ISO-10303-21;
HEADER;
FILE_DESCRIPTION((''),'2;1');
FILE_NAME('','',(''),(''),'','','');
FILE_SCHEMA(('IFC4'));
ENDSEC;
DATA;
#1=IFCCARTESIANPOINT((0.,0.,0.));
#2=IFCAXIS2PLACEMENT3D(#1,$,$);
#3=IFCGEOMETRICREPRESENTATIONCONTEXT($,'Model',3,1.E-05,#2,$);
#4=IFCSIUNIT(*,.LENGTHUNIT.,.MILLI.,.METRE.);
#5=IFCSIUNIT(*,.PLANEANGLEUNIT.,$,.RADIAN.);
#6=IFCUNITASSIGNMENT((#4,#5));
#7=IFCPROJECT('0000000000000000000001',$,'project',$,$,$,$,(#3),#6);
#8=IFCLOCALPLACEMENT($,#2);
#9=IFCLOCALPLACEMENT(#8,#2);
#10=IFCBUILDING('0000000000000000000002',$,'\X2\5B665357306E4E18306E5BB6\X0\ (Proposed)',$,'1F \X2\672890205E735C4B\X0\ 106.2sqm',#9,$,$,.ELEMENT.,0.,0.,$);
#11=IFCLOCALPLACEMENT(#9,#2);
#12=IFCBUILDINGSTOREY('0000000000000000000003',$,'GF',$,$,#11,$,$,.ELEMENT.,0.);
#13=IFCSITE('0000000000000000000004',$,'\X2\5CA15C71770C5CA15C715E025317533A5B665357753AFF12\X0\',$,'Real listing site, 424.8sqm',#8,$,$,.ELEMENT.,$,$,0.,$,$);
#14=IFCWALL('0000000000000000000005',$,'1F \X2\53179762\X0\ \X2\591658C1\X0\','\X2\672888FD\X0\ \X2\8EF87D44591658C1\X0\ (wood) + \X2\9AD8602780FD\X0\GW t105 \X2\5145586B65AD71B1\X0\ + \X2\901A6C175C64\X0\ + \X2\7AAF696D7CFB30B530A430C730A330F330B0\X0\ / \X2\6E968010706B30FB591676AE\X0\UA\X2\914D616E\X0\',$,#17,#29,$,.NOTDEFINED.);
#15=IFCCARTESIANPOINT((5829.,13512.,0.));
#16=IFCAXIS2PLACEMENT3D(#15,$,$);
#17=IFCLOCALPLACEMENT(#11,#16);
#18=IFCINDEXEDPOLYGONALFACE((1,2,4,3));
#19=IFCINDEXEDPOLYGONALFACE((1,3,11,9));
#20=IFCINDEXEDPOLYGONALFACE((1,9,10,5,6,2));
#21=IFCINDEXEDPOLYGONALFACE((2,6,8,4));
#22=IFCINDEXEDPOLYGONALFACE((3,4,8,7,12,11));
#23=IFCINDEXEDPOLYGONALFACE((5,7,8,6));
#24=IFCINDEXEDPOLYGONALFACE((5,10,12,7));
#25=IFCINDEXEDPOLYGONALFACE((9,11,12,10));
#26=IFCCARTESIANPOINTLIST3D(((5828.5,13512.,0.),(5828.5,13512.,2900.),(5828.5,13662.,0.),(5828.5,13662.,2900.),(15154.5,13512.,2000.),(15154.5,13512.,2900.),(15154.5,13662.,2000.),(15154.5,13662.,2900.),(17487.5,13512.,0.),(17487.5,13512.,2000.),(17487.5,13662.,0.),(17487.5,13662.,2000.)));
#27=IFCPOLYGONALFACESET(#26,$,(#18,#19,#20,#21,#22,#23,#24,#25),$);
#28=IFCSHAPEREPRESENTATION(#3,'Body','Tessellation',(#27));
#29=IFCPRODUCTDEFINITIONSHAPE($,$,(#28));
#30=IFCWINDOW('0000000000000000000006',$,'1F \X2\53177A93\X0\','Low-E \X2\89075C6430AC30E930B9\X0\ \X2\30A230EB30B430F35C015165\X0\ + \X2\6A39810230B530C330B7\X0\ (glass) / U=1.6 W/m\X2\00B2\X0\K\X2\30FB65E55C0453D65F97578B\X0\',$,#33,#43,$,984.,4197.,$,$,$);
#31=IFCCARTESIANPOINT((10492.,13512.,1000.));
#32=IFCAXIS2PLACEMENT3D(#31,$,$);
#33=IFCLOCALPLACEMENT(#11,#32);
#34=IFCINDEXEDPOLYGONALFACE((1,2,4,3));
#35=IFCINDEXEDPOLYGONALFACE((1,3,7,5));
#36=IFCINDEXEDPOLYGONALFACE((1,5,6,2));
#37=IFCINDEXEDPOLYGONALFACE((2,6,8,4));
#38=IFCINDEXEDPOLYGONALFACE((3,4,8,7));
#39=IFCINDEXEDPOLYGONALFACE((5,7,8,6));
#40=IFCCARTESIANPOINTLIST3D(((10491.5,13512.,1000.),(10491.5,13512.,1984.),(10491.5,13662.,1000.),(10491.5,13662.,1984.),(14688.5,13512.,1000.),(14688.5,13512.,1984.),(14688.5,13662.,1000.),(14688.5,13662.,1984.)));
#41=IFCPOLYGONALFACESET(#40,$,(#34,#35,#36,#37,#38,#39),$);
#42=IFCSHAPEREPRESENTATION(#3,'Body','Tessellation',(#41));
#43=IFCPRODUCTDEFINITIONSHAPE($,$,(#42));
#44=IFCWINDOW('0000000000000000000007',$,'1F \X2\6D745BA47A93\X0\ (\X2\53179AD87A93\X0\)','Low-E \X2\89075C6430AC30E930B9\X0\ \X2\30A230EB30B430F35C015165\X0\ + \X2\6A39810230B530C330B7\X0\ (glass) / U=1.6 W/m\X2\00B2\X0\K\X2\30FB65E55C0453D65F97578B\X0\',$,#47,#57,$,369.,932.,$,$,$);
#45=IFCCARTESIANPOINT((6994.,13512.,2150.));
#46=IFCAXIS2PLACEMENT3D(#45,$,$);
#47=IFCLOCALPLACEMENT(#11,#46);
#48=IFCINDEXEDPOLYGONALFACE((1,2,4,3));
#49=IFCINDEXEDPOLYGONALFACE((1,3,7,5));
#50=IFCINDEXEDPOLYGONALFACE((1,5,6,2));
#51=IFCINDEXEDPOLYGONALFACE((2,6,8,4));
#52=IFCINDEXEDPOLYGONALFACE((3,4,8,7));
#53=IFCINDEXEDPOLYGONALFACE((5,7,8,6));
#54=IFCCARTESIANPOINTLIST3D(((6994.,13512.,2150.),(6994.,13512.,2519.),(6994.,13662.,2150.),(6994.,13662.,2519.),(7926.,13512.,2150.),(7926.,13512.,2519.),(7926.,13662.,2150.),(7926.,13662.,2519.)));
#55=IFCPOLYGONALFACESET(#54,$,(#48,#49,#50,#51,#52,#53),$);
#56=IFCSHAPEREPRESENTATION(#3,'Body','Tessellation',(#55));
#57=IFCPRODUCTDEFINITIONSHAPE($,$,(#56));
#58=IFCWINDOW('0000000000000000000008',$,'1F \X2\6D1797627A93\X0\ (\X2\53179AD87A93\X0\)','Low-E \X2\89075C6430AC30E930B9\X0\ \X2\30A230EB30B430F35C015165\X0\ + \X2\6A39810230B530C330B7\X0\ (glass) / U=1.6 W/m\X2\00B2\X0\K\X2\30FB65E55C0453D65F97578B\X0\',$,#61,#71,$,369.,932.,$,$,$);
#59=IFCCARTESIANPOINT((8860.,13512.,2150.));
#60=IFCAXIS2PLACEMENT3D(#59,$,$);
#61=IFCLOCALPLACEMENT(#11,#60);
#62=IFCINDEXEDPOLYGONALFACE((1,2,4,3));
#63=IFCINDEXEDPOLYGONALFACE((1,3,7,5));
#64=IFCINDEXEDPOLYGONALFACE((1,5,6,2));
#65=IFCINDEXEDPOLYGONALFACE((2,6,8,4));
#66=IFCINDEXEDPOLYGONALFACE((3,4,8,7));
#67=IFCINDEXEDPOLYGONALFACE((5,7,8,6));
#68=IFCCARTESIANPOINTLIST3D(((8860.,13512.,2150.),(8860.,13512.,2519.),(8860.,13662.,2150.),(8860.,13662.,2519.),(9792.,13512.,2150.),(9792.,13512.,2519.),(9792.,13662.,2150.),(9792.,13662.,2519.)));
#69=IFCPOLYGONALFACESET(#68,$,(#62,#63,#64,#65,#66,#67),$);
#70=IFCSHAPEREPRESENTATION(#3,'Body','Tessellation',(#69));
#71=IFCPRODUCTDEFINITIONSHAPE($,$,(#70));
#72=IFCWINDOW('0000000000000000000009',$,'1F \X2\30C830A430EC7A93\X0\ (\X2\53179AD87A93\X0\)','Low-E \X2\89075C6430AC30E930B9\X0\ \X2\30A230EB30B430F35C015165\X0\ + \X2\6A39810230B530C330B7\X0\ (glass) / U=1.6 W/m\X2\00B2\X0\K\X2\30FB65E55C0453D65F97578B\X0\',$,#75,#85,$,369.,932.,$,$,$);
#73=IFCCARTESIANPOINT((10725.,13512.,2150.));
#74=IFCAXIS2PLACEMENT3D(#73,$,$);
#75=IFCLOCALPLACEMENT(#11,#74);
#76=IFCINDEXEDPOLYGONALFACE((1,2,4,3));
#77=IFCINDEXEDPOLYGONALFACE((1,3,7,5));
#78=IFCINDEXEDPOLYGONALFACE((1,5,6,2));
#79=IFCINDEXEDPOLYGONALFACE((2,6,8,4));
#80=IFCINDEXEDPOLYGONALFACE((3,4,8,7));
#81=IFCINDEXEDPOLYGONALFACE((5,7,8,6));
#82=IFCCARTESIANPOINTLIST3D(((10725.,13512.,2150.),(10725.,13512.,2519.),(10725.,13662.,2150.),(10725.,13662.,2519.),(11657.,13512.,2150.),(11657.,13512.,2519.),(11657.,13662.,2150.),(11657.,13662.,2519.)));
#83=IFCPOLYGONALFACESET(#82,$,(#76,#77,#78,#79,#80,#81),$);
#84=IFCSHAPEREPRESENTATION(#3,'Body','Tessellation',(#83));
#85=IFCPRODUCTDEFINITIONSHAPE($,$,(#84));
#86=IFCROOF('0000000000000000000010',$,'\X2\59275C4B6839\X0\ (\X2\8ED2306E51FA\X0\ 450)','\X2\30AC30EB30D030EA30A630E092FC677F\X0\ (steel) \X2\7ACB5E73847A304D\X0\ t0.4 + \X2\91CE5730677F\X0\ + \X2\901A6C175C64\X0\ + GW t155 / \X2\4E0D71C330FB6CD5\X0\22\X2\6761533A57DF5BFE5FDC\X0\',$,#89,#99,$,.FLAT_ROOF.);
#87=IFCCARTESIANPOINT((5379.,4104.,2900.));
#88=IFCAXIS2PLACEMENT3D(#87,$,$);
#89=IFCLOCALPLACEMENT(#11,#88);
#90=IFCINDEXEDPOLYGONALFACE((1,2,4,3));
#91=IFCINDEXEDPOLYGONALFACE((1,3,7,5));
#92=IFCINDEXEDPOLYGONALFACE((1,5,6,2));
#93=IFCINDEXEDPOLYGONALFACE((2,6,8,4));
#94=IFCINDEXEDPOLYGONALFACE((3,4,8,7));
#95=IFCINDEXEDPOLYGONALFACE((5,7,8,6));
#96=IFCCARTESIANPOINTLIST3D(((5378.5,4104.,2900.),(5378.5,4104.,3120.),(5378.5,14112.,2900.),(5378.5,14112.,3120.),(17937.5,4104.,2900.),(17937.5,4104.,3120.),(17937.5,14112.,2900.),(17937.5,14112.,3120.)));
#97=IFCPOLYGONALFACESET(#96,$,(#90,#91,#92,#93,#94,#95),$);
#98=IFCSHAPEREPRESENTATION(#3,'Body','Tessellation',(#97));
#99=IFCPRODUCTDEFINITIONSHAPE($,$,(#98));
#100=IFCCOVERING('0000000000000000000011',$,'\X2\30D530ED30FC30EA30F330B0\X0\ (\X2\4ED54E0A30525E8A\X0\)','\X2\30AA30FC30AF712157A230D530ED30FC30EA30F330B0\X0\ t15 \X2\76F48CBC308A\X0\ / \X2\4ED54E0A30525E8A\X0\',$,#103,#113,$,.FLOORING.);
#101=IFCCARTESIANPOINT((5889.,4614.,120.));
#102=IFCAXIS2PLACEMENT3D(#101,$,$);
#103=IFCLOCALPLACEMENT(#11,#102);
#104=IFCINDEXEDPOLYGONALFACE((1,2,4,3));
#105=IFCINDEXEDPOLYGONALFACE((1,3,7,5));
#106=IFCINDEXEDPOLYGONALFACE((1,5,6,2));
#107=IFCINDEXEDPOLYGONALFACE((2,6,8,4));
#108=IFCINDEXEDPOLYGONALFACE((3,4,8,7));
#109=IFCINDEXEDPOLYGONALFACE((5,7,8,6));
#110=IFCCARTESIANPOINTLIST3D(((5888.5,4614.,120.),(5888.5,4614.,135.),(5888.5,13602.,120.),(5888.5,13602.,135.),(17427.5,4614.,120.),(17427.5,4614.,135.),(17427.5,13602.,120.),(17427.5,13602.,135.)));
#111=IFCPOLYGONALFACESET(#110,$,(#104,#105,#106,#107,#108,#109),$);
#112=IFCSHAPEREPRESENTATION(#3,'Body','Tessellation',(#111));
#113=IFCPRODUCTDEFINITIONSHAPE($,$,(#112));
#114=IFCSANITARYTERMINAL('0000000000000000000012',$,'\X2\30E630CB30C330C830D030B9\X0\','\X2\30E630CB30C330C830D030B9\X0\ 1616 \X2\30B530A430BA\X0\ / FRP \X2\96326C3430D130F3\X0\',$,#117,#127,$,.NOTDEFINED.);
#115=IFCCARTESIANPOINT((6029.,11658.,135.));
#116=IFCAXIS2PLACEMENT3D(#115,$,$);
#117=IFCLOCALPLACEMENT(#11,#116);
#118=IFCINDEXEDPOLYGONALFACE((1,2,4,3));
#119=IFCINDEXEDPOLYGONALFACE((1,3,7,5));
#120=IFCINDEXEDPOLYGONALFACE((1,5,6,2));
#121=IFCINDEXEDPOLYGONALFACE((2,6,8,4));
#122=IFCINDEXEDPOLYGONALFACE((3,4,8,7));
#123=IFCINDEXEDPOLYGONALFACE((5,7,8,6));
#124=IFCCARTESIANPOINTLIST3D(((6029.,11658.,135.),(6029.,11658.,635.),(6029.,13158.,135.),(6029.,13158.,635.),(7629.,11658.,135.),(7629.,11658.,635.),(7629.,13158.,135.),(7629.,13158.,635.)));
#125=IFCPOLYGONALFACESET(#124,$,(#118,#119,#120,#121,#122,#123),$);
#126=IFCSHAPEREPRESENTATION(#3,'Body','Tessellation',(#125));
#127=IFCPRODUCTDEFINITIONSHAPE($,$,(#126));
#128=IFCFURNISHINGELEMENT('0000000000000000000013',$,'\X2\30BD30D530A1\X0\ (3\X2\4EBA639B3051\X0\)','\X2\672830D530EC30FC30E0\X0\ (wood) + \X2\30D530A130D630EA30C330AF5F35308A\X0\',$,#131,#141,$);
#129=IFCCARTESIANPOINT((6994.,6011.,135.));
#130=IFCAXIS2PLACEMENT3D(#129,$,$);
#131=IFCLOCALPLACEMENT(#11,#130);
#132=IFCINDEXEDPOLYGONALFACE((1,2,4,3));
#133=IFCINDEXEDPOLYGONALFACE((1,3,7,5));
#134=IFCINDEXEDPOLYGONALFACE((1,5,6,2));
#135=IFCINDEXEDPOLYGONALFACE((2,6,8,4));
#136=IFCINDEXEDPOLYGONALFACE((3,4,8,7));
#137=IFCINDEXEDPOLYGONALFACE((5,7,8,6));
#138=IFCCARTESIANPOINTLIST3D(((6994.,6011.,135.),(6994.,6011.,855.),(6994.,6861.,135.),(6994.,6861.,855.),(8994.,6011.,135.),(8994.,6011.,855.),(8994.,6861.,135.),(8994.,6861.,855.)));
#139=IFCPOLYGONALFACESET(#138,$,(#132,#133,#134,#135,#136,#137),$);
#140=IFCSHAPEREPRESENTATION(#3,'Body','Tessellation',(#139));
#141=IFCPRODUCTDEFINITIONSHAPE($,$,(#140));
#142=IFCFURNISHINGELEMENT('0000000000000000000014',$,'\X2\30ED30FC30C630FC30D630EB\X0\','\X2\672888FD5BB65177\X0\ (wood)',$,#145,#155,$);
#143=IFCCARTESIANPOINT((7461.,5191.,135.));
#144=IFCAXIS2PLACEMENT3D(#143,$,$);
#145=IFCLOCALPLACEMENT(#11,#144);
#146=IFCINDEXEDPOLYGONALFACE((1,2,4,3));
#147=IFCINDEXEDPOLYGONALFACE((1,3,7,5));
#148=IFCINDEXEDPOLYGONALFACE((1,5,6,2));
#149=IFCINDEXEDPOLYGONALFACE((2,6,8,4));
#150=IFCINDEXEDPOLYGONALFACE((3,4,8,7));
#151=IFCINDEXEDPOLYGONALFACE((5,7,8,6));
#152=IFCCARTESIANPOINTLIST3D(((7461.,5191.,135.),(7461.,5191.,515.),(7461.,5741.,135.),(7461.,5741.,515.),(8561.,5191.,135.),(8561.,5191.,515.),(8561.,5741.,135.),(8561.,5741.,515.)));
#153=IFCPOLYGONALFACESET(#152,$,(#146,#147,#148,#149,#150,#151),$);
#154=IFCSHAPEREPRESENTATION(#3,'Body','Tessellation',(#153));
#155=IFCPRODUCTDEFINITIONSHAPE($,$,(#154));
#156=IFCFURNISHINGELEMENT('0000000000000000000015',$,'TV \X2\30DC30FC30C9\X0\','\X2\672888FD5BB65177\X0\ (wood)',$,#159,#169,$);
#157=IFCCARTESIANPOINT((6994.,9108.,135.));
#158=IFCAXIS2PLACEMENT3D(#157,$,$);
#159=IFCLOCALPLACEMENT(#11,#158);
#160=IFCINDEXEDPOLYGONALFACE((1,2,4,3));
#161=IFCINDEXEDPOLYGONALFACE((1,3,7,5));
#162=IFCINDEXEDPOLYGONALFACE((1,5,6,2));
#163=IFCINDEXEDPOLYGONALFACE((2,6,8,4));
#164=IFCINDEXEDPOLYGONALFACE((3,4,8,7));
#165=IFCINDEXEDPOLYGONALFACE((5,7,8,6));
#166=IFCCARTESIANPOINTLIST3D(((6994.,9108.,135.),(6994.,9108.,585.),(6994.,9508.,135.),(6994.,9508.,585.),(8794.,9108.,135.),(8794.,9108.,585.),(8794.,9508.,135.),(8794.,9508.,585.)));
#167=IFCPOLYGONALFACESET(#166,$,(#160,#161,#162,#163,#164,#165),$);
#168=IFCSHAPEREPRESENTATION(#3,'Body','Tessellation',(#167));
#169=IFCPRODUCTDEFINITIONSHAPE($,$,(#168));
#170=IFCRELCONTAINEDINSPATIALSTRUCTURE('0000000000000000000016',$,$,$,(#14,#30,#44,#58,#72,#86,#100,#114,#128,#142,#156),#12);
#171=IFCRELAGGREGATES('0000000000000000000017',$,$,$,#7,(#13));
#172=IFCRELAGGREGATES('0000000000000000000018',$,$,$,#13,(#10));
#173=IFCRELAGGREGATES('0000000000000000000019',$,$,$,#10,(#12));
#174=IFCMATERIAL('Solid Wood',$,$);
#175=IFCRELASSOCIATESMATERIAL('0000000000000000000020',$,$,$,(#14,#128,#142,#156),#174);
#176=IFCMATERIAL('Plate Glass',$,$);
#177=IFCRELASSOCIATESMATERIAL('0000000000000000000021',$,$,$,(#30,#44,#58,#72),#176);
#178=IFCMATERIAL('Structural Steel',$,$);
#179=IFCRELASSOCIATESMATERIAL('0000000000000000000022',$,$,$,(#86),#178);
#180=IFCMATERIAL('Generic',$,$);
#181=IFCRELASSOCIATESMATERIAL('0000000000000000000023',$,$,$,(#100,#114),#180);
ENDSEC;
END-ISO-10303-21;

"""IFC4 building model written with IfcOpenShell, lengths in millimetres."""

from ifc_helpers import new_model, si_unit, frame, frame_2d, origin, place, context, project, spatial, rectangle, extrude, material, element, fill, save


model = new_model("IFC4")

# Units and contexts
model_context = context("Model", 3, precision=1e-05, world=origin())
ifc_project = project(units=[si_unit("LENGTHUNIT", "METRE", prefix="MILLI"), si_unit("PLANEANGLEUNIT", "RADIAN")], contexts=[model_context])

# Site, building, storey
site_placement = place(None, origin())
site = spatial("IfcSite", under=ifc_project, at=site_placement, Name="岡山県岡山市北区学南町２", ObjectType="Real listing site, 424.8sqm", CompositionType="ELEMENT", RefElevation=0.0)
building_placement = place(site_placement, origin())
building = spatial("IfcBuilding", under=site, at=building_placement, Name="学南の丘の家 (Proposed)", ObjectType="1F 木造平屋 106.2sqm", CompositionType="ELEMENT", ElevationOfRefHeight=0.0, ElevationOfTerrain=0.0)
storey_placement = place(building_placement, origin())
storey = spatial("IfcBuildingStorey", under=building, at=storey_placement, Name="GF", CompositionType="ELEMENT", Elevation=0.0)

# Shared definitions
ifc_material_1 = material(Name="Solid Wood")

# Shared definitions
ifc_material_2 = material(Name="Plate Glass")

# Wall, openings, windows
wall_1_placement = place(storey_placement, frame((5829.0, 13512.0, 0.0)))
wall_1 = element("IfcWall", 1, at=wall_1_placement, inside=storey, material=ifc_material_1, Name="1F 北面 外壁", Description="木製 軸組外壁 (wood) + 高性能GW t105 充填断熱 + 通気層 + 窯業系サイディング / 準耐火・外皮UA配慮", PredefinedType="NOTDEFINED", context=model_context, shape_type="SweptSolid", body=[
    extrude(rectangle(XDim=11659.0, YDim=150.0, at=frame_2d((5829.0, 75.0))), frame((5829.0, 13512.0, 0.0)), (0.0, 0.0, 1.0), 2900.0),
])
opening_1_placement = place(storey_placement, frame((10492.0, 13512.0, 1000.0)))
opening_1 = element("IfcOpeningElement", 2, at=opening_1_placement, cuts=wall_1, PredefinedType="NOTDEFINED", context=model_context, shape_type="SweptSolid", body=[
    extrude(rectangle(XDim=4197.0, YDim=150.0, at=frame_2d((2098.0, 75.0))), frame((10492.0, 13512.0, 1000.0)), (0.0, 0.0, 1.0), 984.0),
])
opening_2_placement = place(storey_placement, frame((6994.0, 13512.0, 2150.0)))
opening_2 = element("IfcOpeningElement", 3, at=opening_2_placement, cuts=wall_1, PredefinedType="NOTDEFINED", context=model_context, shape_type="SweptSolid", body=[
    extrude(rectangle(XDim=932.0, YDim=150.0, at=frame_2d((466.0, 75.0))), frame((6994.0, 13512.0, 2150.0)), (0.0, 0.0, 1.0), 369.0),
])
opening_3_placement = place(storey_placement, frame((8860.0, 13512.0, 2150.0)))
opening_3 = element("IfcOpeningElement", 4, at=opening_3_placement, cuts=wall_1, PredefinedType="NOTDEFINED", context=model_context, shape_type="SweptSolid", body=[
    extrude(rectangle(XDim=932.0, YDim=150.0, at=frame_2d((466.0, 75.0))), frame((8860.0, 13512.0, 2150.0)), (0.0, 0.0, 1.0), 369.0),
])
opening_4_placement = place(storey_placement, frame((10725.0, 13512.0, 2150.0)))
opening_4 = element("IfcOpeningElement", 5, at=opening_4_placement, cuts=wall_1, PredefinedType="NOTDEFINED", context=model_context, shape_type="SweptSolid", body=[
    extrude(rectangle(XDim=932.0, YDim=150.0, at=frame_2d((466.0, 75.0))), frame((10725.0, 13512.0, 2150.0)), (0.0, 0.0, 1.0), 369.0),
])
window_1_placement = place(storey_placement, frame((10492.0, 13512.0, 1000.0)))
window_1 = element("IfcWindow", 6, at=window_1_placement, inside=storey, material=ifc_material_2, Name="1F 北窓", Description="Low-E 複層ガラス アルゴン封入 + 樹脂サッシ (glass) / U=1.6 W/m²K・日射取得型", OverallHeight=984.0, OverallWidth=4197.0, context=model_context, shape_type="SweptSolid", body=[
    extrude(rectangle(XDim=4197.0, YDim=150.0, at=frame_2d((2098.0, 75.0))), frame((10492.0, 13512.0, 1000.0)), (0.0, 0.0, 1.0), 984.0),
])
fill(opening_1, window_1)
window_2_placement = place(storey_placement, frame((6994.0, 13512.0, 2150.0)))
window_2 = element("IfcWindow", 7, at=window_2_placement, inside=storey, material=ifc_material_2, Name="1F 浴室窓 (北高窓)", Description="Low-E 複層ガラス アルゴン封入 + 樹脂サッシ (glass) / U=1.6 W/m²K・日射取得型", OverallHeight=369.0, OverallWidth=932.0, context=model_context, shape_type="SweptSolid", body=[
    extrude(rectangle(XDim=932.0, YDim=150.0, at=frame_2d((466.0, 75.0))), frame((6994.0, 13512.0, 2150.0)), (0.0, 0.0, 1.0), 369.0),
])
fill(opening_2, window_2)
window_3_placement = place(storey_placement, frame((8860.0, 13512.0, 2150.0)))
window_3 = element("IfcWindow", 8, at=window_3_placement, inside=storey, material=ifc_material_2, Name="1F 洗面窓 (北高窓)", Description="Low-E 複層ガラス アルゴン封入 + 樹脂サッシ (glass) / U=1.6 W/m²K・日射取得型", OverallHeight=369.0, OverallWidth=932.0, context=model_context, shape_type="SweptSolid", body=[
    extrude(rectangle(XDim=932.0, YDim=150.0, at=frame_2d((466.0, 75.0))), frame((8860.0, 13512.0, 2150.0)), (0.0, 0.0, 1.0), 369.0),
])
fill(opening_3, window_3)
window_4_placement = place(storey_placement, frame((10725.0, 13512.0, 2150.0)))
window_4 = element("IfcWindow", 9, at=window_4_placement, inside=storey, material=ifc_material_2, Name="1F トイレ窓 (北高窓)", Description="Low-E 複層ガラス アルゴン封入 + 樹脂サッシ (glass) / U=1.6 W/m²K・日射取得型", OverallHeight=369.0, OverallWidth=932.0, context=model_context, shape_type="SweptSolid", body=[
    extrude(rectangle(XDim=932.0, YDim=150.0, at=frame_2d((466.0, 75.0))), frame((10725.0, 13512.0, 2150.0)), (0.0, 0.0, 1.0), 369.0),
])
fill(opening_4, window_4)

# Roof
ifc_material_3 = material(Name="Structural Steel")
roof_placement = place(storey_placement, frame((5379.0, 4104.0, 2900.0)))
element("IfcRoof", 10, at=roof_placement, inside=storey, material=ifc_material_3, Name="大屋根 (軒の出 450)", Description="ガルバリウム鋼板 (steel) 立平葺き t0.4 + 野地板 + 通気層 + GW t155 / 不燃・法22条区域対応", PredefinedType="FLAT_ROOF", context=model_context, shape_type="SweptSolid", body=[
    extrude(rectangle(XDim=12559.0, YDim=10008.0, at=frame_2d((6279.0, 5004.0))), frame((5379.0, 4104.0, 2900.0)), (0.0, 0.0, 1.0), 220.0),
])

# Covering
ifc_material_4 = material(Name="Generic")
covering_placement = place(storey_placement, frame((5889.0, 4614.0, 120.0)))
element("IfcCovering", 11, at=covering_placement, inside=storey, material=ifc_material_4, Name="フローリング (仕上げ床)", Description="オーク無垢フローリング t15 直貼り / 仕上げ床", PredefinedType="FLOORING", context=model_context, shape_type="SweptSolid", body=[
    extrude(rectangle(XDim=11539.0, YDim=8988.0, at=frame_2d((5769.0, 4494.0))), frame((5889.0, 4614.0, 120.0)), (0.0, 0.0, 1.0), 15.0),
])

# Sanitary terminal
sanitary_terminal_placement = place(storey_placement, frame((6029.0, 11658.0, 135.0)))
element("IfcSanitaryTerminal", 12, at=sanitary_terminal_placement, inside=storey, material=ifc_material_4, Name="ユニットバス", Description="ユニットバス 1616 サイズ / FRP 防水パン", PredefinedType="NOTDEFINED", context=model_context, shape_type="SweptSolid", body=[
    extrude(rectangle(XDim=1600.0, YDim=1500.0, at=frame_2d((800.0, 750.0))), frame((6029.0, 11658.0, 135.0)), (0.0, 0.0, 1.0), 500.0),
])

# Furnishing elements
furnishing_1_placement = place(storey_placement, frame((6994.0, 6011.0, 135.0)))
element("IfcFurnishingElement", 13, at=furnishing_1_placement, inside=storey, material=ifc_material_1, Name="ソファ (3人掛け)", Description="木フレーム (wood) + ファブリック張り", context=model_context, shape_type="SweptSolid", body=[
    extrude(rectangle(XDim=2000.0, YDim=850.0, at=frame_2d((1000.0, 425.0))), frame((6994.0, 6011.0, 135.0)), (0.0, 0.0, 1.0), 720.0),
])
furnishing_2_placement = place(storey_placement, frame((7461.0, 5191.0, 135.0)))
element("IfcFurnishingElement", 14, at=furnishing_2_placement, inside=storey, material=ifc_material_1, Name="ローテーブル", Description="木製家具 (wood)", context=model_context, shape_type="SweptSolid", body=[
    extrude(rectangle(XDim=1100.0, YDim=550.0, at=frame_2d((550.0, 275.0))), frame((7461.0, 5191.0, 135.0)), (0.0, 0.0, 1.0), 380.0),
])
furnishing_3_placement = place(storey_placement, frame((6994.0, 9108.0, 135.0)))
element("IfcFurnishingElement", 15, at=furnishing_3_placement, inside=storey, material=ifc_material_1, Name="TV ボード", Description="木製家具 (wood)", context=model_context, shape_type="SweptSolid", body=[
    extrude(rectangle(XDim=1800.0, YDim=400.0, at=frame_2d((900.0, 200.0))), frame((6994.0, 9108.0, 135.0)), (0.0, 0.0, 1.0), 450.0),
])

save(model, "model.ifc")
